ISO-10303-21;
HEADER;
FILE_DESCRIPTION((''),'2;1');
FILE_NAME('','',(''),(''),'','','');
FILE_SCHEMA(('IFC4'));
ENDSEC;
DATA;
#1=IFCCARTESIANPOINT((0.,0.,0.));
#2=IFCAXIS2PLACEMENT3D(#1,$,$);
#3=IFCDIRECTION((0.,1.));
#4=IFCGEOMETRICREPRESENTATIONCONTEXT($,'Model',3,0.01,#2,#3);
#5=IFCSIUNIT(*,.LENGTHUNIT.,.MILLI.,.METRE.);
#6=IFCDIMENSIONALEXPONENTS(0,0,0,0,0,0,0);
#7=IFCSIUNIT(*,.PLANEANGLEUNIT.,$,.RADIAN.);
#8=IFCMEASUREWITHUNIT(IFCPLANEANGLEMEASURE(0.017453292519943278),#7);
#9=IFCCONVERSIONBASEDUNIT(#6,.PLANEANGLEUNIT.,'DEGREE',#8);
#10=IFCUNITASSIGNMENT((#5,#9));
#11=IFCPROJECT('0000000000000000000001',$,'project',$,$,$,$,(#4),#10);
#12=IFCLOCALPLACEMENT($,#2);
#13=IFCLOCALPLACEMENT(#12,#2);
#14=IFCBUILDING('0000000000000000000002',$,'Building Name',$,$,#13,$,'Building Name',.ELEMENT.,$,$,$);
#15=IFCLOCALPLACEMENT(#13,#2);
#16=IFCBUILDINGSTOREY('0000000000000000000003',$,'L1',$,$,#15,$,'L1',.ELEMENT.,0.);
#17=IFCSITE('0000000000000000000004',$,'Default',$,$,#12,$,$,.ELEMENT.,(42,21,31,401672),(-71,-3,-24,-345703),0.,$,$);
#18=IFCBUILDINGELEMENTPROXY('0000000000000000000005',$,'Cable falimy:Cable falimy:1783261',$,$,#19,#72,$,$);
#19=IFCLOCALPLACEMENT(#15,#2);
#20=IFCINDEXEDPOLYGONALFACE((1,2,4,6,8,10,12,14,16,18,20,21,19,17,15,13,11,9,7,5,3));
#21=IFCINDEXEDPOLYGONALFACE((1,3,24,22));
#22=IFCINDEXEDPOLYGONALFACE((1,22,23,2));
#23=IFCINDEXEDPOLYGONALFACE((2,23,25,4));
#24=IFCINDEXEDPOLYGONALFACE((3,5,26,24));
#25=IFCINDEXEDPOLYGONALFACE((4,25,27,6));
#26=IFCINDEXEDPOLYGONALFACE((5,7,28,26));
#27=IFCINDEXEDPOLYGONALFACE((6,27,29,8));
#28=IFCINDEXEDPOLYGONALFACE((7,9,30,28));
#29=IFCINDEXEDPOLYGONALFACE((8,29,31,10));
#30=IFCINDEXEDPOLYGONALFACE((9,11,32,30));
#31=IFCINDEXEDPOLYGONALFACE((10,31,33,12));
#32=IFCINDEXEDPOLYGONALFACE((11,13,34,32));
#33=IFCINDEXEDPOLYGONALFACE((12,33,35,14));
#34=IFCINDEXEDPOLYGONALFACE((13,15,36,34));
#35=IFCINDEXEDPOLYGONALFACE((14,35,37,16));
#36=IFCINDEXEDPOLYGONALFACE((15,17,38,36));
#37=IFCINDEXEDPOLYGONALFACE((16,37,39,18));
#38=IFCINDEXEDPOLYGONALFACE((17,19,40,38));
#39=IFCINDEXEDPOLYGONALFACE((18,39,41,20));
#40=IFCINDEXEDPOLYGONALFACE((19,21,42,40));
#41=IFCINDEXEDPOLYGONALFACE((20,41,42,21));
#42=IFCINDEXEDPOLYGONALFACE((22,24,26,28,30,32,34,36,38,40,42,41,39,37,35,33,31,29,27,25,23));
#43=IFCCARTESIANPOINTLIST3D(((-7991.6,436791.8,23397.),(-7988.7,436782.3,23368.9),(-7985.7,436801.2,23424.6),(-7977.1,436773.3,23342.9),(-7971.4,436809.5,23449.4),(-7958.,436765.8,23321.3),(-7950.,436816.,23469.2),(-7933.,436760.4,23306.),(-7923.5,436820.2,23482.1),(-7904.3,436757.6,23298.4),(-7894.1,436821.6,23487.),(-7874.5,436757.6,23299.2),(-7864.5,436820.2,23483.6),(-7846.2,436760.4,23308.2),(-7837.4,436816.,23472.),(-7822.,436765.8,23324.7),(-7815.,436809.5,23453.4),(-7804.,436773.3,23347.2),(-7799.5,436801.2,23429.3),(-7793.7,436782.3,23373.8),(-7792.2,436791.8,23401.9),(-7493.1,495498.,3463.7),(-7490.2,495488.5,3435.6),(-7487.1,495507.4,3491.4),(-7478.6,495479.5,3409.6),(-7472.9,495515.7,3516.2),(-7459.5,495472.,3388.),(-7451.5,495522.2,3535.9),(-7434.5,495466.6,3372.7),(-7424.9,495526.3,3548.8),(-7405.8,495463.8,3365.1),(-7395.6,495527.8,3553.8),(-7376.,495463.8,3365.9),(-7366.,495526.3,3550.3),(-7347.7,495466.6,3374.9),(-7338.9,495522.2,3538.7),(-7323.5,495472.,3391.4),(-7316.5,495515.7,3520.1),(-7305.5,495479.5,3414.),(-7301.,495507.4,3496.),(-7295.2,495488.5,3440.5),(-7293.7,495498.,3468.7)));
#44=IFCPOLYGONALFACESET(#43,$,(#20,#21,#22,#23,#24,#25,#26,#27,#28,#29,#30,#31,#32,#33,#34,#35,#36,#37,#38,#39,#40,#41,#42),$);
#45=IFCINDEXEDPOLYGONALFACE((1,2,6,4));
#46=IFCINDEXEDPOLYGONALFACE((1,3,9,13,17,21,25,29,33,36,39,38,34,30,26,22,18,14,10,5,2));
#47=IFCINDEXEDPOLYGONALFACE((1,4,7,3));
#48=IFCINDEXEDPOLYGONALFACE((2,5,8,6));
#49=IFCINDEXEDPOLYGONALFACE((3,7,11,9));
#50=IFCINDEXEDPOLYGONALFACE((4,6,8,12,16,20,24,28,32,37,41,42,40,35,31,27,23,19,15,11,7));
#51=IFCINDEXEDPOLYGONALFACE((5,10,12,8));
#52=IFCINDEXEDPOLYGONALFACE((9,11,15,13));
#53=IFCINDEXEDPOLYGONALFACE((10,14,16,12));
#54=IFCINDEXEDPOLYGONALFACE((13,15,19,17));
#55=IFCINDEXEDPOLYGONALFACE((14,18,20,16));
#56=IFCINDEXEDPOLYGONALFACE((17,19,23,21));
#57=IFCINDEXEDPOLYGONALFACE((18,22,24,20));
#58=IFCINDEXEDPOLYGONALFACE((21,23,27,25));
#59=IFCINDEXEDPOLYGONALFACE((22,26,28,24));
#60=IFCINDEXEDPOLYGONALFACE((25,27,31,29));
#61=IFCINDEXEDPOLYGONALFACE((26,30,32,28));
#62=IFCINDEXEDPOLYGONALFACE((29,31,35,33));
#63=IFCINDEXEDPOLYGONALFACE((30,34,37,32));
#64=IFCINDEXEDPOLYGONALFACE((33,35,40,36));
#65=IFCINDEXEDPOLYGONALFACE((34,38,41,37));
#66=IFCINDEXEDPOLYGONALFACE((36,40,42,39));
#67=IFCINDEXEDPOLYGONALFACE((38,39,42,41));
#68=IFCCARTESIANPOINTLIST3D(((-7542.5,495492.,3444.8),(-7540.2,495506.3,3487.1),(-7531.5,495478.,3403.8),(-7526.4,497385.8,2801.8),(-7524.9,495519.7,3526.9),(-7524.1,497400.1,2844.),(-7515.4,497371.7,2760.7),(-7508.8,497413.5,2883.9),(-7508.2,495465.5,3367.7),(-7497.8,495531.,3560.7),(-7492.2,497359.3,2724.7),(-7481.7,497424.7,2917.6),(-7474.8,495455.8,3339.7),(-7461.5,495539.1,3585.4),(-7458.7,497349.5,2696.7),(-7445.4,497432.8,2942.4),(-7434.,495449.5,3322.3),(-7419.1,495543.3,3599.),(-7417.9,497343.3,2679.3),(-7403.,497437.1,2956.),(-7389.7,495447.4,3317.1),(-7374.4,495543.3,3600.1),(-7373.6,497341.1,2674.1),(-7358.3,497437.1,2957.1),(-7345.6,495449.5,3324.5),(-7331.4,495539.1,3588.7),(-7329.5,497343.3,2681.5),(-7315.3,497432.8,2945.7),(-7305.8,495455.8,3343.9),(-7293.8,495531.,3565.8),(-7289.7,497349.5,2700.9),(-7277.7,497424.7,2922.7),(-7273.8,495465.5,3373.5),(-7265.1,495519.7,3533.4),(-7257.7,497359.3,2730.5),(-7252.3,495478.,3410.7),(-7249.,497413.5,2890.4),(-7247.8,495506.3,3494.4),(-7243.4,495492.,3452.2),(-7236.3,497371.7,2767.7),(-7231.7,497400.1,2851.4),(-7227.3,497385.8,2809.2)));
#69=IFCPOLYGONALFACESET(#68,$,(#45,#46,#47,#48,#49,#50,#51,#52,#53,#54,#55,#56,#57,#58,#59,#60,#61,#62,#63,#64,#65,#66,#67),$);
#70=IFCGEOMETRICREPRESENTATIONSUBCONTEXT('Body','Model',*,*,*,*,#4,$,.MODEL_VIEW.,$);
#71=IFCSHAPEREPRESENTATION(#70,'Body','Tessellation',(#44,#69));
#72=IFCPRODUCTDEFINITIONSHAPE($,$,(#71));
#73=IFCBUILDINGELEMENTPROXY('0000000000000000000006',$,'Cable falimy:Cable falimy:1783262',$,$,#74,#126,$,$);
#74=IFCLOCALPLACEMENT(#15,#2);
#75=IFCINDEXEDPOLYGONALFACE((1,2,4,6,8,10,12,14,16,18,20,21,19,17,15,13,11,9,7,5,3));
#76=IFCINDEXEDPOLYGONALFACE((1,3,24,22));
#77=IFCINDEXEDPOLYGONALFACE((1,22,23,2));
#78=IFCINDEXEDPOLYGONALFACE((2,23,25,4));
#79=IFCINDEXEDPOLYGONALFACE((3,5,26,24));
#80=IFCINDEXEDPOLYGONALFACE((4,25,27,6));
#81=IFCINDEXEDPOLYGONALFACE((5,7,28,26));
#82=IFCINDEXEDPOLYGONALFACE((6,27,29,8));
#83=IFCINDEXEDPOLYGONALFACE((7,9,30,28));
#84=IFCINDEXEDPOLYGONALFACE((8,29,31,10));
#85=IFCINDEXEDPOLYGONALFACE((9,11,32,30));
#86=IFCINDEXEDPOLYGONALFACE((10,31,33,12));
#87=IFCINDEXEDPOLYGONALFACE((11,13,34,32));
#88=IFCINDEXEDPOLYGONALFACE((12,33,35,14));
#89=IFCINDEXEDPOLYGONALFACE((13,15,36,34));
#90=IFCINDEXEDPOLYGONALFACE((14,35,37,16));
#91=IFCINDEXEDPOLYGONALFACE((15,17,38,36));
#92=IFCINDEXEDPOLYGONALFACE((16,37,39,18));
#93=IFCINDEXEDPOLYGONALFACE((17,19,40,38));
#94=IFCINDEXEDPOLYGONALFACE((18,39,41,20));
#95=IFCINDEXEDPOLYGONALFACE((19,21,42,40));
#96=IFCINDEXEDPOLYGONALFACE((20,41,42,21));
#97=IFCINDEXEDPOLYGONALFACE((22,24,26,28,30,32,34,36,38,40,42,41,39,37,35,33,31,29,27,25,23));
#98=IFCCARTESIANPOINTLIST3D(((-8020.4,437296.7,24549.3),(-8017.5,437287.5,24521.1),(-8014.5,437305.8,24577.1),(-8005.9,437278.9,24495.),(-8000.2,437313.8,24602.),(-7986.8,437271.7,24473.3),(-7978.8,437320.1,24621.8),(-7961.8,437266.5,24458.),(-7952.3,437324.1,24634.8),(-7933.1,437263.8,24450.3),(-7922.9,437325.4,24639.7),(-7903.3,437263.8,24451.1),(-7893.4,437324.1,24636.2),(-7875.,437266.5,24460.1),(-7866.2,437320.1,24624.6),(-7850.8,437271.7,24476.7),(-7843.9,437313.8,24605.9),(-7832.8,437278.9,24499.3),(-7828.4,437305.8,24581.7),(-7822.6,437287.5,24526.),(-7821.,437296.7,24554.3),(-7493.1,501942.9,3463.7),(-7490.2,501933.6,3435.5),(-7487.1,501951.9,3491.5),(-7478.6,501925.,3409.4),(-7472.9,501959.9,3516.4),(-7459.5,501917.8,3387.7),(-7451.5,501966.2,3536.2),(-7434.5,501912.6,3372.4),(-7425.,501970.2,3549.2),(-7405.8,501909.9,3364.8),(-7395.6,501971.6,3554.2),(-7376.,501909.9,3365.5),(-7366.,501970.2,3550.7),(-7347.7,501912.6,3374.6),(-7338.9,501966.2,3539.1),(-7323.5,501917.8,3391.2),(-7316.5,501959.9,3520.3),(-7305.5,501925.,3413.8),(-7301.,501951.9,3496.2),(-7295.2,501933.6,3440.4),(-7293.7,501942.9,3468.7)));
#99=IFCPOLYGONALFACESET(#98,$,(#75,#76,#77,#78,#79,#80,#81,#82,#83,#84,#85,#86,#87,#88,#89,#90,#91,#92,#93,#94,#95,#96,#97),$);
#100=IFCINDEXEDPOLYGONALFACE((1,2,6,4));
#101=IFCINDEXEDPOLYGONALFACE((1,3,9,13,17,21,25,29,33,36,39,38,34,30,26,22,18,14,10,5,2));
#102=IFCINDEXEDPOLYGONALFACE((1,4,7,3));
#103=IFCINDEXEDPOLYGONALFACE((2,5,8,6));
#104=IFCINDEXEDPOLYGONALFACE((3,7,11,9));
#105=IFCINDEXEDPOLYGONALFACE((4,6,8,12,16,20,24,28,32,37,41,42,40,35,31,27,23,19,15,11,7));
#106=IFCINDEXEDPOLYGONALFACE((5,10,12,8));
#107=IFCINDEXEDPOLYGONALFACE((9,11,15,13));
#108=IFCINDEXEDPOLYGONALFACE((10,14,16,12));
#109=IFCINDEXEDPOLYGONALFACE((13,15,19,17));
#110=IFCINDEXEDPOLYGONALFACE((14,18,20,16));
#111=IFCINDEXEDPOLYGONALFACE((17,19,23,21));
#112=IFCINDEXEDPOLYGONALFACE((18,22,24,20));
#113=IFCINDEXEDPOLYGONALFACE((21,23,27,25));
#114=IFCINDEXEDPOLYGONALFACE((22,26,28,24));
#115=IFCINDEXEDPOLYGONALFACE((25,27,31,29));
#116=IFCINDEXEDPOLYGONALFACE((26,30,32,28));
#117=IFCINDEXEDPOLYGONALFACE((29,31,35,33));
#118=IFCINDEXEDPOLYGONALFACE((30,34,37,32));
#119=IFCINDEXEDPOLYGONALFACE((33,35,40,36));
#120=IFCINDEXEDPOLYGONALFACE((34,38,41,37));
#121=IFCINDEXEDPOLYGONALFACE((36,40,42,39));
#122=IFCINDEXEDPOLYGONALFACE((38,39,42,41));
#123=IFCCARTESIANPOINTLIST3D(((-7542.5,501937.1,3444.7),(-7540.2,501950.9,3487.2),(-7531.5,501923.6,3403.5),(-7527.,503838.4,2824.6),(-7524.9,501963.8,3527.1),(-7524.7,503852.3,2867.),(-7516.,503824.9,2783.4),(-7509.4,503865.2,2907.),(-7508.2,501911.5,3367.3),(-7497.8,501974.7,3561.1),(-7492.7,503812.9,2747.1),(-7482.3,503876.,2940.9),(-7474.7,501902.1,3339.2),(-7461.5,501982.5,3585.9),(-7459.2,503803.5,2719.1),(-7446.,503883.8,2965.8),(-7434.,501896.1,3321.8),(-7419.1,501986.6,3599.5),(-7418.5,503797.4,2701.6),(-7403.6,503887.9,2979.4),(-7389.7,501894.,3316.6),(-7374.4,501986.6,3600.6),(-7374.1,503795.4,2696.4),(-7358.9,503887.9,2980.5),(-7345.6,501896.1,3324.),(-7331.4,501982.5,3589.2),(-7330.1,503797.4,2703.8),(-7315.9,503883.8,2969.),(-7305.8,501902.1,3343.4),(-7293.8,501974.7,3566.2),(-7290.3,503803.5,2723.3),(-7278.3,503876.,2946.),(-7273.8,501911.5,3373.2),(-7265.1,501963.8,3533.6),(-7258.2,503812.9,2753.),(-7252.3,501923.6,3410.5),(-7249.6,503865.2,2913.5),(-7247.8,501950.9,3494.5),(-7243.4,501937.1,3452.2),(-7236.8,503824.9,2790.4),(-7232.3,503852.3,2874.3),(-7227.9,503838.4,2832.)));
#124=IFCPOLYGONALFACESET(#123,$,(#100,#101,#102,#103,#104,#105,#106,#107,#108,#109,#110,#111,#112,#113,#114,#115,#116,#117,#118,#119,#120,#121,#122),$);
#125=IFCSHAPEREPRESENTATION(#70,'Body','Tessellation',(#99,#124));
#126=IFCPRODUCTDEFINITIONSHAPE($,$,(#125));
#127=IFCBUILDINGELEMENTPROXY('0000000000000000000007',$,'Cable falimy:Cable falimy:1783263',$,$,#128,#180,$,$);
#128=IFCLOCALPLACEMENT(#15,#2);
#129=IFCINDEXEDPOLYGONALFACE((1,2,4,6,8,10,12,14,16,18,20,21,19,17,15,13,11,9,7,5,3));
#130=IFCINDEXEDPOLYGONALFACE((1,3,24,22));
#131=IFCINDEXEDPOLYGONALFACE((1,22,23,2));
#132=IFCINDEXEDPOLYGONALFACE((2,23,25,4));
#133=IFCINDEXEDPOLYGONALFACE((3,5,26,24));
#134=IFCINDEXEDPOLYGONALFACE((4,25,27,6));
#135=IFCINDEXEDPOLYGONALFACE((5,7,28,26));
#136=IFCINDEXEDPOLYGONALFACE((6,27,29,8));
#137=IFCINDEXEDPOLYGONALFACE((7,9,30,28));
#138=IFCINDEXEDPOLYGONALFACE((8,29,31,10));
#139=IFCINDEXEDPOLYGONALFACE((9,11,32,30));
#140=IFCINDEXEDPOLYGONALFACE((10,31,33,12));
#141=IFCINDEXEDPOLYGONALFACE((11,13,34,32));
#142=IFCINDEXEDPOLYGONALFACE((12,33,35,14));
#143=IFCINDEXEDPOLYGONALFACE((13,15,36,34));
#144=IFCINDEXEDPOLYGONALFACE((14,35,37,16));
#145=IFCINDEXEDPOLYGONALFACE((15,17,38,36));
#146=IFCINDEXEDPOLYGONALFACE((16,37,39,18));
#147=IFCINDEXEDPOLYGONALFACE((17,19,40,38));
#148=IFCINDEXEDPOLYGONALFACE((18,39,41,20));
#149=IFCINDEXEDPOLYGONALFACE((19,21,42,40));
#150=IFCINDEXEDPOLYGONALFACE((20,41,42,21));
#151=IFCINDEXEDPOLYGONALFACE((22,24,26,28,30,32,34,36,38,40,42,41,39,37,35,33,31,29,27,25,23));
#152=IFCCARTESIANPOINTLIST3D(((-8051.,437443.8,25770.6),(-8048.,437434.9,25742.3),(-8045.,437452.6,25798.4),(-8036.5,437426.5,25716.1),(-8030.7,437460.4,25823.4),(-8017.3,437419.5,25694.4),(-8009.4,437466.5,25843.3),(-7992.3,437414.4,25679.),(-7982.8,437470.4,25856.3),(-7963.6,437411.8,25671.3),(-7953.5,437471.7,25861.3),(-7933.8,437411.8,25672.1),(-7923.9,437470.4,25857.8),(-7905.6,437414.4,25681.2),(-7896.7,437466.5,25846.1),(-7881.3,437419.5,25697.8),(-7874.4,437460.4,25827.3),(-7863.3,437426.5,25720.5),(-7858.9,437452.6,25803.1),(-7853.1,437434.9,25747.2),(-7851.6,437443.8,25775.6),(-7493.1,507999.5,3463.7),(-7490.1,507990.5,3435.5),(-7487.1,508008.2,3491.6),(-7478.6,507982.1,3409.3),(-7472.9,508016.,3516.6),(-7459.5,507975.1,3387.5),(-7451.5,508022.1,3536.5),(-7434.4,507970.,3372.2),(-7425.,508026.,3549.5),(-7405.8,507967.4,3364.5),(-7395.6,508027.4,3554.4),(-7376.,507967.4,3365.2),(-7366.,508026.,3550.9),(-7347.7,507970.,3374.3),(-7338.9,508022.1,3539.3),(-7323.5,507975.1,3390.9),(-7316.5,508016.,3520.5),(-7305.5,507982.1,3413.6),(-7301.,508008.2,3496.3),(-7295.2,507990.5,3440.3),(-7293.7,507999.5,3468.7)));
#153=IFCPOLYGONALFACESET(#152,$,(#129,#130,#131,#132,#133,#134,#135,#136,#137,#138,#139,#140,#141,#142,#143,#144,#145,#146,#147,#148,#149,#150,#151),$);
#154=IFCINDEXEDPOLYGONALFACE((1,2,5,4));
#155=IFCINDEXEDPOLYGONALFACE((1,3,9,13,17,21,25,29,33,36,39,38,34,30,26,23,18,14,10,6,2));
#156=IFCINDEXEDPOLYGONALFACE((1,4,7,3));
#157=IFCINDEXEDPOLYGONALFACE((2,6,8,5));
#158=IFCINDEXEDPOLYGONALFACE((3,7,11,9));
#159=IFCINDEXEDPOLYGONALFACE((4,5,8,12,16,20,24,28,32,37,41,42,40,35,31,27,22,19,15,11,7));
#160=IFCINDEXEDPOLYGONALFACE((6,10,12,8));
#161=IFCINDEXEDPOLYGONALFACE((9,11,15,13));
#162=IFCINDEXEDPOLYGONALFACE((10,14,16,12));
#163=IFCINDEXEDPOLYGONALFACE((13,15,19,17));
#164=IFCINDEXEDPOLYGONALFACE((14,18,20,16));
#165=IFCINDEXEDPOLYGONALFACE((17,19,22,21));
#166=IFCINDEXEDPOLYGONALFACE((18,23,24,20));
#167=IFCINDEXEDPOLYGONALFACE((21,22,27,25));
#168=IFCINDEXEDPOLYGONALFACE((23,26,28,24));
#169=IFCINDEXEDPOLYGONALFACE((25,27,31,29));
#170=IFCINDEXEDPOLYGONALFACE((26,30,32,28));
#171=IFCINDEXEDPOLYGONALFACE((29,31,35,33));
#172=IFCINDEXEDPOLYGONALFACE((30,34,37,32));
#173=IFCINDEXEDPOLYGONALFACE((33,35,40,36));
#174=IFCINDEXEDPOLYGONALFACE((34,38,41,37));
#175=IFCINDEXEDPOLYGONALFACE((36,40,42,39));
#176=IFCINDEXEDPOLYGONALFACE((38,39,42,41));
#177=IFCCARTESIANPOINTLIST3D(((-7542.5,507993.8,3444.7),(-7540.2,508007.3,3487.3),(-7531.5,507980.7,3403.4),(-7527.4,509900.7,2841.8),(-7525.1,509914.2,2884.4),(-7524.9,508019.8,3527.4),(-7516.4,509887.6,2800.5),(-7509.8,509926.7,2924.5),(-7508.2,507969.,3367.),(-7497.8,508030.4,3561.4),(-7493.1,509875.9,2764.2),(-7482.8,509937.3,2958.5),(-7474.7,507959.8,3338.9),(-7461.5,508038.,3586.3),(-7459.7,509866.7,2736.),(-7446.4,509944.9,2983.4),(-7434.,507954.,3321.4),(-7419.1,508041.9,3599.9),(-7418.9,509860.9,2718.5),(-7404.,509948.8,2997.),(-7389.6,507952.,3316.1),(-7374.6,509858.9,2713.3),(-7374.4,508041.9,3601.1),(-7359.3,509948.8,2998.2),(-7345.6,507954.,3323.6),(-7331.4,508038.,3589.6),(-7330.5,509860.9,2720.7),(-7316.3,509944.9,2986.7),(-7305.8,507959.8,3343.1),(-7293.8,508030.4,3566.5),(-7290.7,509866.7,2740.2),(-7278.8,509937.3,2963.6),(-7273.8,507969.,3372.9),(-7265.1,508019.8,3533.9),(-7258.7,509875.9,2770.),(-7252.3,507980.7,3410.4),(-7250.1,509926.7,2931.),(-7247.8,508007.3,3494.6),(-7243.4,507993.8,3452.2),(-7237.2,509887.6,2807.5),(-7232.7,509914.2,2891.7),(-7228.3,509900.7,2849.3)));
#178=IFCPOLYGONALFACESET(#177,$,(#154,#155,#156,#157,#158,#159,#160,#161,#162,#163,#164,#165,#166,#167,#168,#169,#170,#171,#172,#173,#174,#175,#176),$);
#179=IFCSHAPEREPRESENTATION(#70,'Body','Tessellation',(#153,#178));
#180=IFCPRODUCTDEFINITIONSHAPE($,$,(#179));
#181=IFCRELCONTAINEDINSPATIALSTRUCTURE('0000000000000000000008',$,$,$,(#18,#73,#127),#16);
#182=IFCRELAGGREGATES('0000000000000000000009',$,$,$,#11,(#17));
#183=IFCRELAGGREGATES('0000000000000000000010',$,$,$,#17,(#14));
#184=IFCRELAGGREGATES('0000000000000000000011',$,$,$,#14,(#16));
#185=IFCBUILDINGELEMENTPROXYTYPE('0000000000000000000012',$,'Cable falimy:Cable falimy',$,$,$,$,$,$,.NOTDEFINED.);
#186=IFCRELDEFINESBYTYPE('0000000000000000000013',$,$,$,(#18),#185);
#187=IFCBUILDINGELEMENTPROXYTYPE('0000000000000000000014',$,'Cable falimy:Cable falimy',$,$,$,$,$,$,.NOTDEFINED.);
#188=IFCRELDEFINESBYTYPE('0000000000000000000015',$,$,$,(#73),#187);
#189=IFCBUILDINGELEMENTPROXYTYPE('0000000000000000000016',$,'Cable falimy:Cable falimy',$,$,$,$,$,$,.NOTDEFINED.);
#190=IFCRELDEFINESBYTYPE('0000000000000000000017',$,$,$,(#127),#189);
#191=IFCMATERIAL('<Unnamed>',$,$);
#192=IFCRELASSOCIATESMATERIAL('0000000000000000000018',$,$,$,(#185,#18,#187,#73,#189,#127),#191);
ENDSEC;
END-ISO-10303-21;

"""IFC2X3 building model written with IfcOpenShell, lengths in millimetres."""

from ifc_helpers import new_model, entity, si_unit, converted_unit, direction, frame, frame_2d, origin, place, context, subcontext, project, spatial, circle, extrude, source, transform, mapped, material, type_object, type_shapes, element, save


model = new_model("IFC2X3")

# Units and contexts
model_context = context("Model", 3, precision=0.01, world=origin(), true_north=direction((0.0, 1.0)))
body_context = subcontext(model_context, "Body", "Model", "MODEL_VIEW")
ifc_project = project(units=[si_unit("LENGTHUNIT", "METRE", prefix="MILLI"), converted_unit("PLANEANGLEUNIT", "DEGREE", entity("IfcPlaneAngleMeasure", 0.017453292519943278), si_unit("PLANEANGLEUNIT", "RADIAN"), dimensions=[0, 0, 0, 0, 0, 0, 0])], contexts=[model_context])

# Site, building, storey
site_placement = place(None, origin())
site = spatial("IfcSite", under=ifc_project, at=site_placement, Name="Default", CompositionType="ELEMENT", RefLatitude=(42, 21, 31, 401672), RefLongitude=(-71, -3, -24, -345703), RefElevation=0.0)
building_placement = place(site_placement, origin())
building = spatial("IfcBuilding", under=site, at=building_placement, Name="Building Name", LongName="Building Name", CompositionType="ELEMENT")
storey_placement = place(building_placement, origin())
storey = spatial("IfcBuildingStorey", under=building, at=storey_placement, Name="L1", LongName="L1", CompositionType="ELEMENT", Elevation=0.0)

# Shared definitions
ifc_material = material(Name="<Unnamed>")

# Building element proxies
building_element_proxy_type_1 = type_object("IfcBuildingElementProxyType", Name="Cable falimy:Cable falimy", PredefinedType="NOTDEFINED", material=ifc_material)
shared_shape_1 = source(origin(), body_context, "Body", "SweptSolid", [
    extrude(circle(Radius=100.0, at=frame_2d((0.0, 0.0), x_axis=(1.0, 0.0))), frame((0.0, 0.0, 0.0), z_axis=(0.946874, 0.0, 0.321605), x_axis=(-0.321605, 0.0, 0.946874)), (0.0, 0.0, 1.0), 62000.0),
    extrude(circle(Radius=150.0, at=frame_2d((0.0, 0.0), x_axis=(1.0, 0.0))), frame((-1893.7, 0.0, -643.2), z_axis=(0.946874, 0.0, 0.321605), x_axis=(0.321605, 0.0, -0.946874)), (0.0, 0.0, 1.0), 2000.0),
])
type_shapes(building_element_proxy_type_1, [shared_shape_1])
proxy_1_placement = place(storey_placement, frame((-7393.2, 495495.6, 3459.1), z_axis=(-0.025001, 0.0, 0.999687), x_axis=(0.0, -1.0, 0.0)))
element("IfcBuildingElementProxy", 1, at=proxy_1_placement, inside=storey, type_object=building_element_proxy_type_1, material=ifc_material, Name="Cable falimy:Cable falimy:1783261", context=body_context, shape_type="MappedRepresentation", body=[
    mapped(shared_shape_1, transform((0.0, 0.0, 0.0), scale=1.0)),
])
building_element_proxy_type_2 = type_object("IfcBuildingElementProxyType", Name="Cable falimy:Cable falimy", PredefinedType="NOTDEFINED", material=ifc_material)
shared_shape_2 = source(origin(), body_context, "Body", "SweptSolid", [
    extrude(circle(Radius=100.0, at=frame_2d((0.0, 0.0), x_axis=(1.0, 0.0))), frame((0.0, 0.0, 0.0), z_axis=(0.950678, 0.0, 0.310179), x_axis=(-0.310179, 0.0, 0.950678)), (0.0, 0.0, 1.0), 68000.0),
    extrude(circle(Radius=150.0, at=frame_2d((0.0, 0.0), x_axis=(1.0, 0.0))), frame((-1901.4, 0.0, -620.4), z_axis=(0.950678, 0.0, 0.310179), x_axis=(0.310179, 0.0, -0.950678)), (0.0, 0.0, 1.0), 2000.0),
])
type_shapes(building_element_proxy_type_2, [shared_shape_2])
proxy_2_placement = place(storey_placement, frame((-7393.2, 501940.6, 3459.1), z_axis=(-0.025001, 0.0, 0.999687), x_axis=(0.0, -1.0, 0.0)))
element("IfcBuildingElementProxy", 2, at=proxy_2_placement, inside=storey, type_object=building_element_proxy_type_2, material=ifc_material, Name="Cable falimy:Cable falimy:1783262", context=body_context, shape_type="MappedRepresentation", body=[
    mapped(shared_shape_2, transform((0.0, 0.0, 0.0), scale=1.0)),
])
building_element_proxy_type_3 = type_object("IfcBuildingElementProxyType", Name="Cable falimy:Cable falimy", PredefinedType="NOTDEFINED", material=ifc_material)
shared_shape_3 = source(origin(), body_context, "Body", "SweptSolid", [
    extrude(circle(Radius=100.0, at=frame_2d((0.0, 0.0), x_axis=(1.0, 0.0))), frame((0.0, 0.0, 0.0), z_axis=(0.953454, 0.0, 0.301538), x_axis=(-0.301538, 0.0, 0.953454)), (0.0, 0.0, 1.0), 74000.0),
    extrude(circle(Radius=150.0, at=frame_2d((0.0, 0.0), x_axis=(1.0, 0.0))), frame((-1906.9, 0.0, -603.1), z_axis=(0.953454, 0.0, 0.301538), x_axis=(0.301538, 0.0, -0.953454)), (0.0, 0.0, 1.0), 2000.0),
])
type_shapes(building_element_proxy_type_3, [shared_shape_3])
proxy_3_placement = place(storey_placement, frame((-7393.2, 507997.2, 3459.1), z_axis=(-0.025001, 0.0, 0.999687), x_axis=(0.0, -1.0, 0.0)))
element("IfcBuildingElementProxy", 3, at=proxy_3_placement, inside=storey, type_object=building_element_proxy_type_3, material=ifc_material, Name="Cable falimy:Cable falimy:1783263", context=body_context, shape_type="MappedRepresentation", body=[
    mapped(shared_shape_3, transform((0.0, 0.0, 0.0), scale=1.0)),
])

save(model, "model.ifc")
